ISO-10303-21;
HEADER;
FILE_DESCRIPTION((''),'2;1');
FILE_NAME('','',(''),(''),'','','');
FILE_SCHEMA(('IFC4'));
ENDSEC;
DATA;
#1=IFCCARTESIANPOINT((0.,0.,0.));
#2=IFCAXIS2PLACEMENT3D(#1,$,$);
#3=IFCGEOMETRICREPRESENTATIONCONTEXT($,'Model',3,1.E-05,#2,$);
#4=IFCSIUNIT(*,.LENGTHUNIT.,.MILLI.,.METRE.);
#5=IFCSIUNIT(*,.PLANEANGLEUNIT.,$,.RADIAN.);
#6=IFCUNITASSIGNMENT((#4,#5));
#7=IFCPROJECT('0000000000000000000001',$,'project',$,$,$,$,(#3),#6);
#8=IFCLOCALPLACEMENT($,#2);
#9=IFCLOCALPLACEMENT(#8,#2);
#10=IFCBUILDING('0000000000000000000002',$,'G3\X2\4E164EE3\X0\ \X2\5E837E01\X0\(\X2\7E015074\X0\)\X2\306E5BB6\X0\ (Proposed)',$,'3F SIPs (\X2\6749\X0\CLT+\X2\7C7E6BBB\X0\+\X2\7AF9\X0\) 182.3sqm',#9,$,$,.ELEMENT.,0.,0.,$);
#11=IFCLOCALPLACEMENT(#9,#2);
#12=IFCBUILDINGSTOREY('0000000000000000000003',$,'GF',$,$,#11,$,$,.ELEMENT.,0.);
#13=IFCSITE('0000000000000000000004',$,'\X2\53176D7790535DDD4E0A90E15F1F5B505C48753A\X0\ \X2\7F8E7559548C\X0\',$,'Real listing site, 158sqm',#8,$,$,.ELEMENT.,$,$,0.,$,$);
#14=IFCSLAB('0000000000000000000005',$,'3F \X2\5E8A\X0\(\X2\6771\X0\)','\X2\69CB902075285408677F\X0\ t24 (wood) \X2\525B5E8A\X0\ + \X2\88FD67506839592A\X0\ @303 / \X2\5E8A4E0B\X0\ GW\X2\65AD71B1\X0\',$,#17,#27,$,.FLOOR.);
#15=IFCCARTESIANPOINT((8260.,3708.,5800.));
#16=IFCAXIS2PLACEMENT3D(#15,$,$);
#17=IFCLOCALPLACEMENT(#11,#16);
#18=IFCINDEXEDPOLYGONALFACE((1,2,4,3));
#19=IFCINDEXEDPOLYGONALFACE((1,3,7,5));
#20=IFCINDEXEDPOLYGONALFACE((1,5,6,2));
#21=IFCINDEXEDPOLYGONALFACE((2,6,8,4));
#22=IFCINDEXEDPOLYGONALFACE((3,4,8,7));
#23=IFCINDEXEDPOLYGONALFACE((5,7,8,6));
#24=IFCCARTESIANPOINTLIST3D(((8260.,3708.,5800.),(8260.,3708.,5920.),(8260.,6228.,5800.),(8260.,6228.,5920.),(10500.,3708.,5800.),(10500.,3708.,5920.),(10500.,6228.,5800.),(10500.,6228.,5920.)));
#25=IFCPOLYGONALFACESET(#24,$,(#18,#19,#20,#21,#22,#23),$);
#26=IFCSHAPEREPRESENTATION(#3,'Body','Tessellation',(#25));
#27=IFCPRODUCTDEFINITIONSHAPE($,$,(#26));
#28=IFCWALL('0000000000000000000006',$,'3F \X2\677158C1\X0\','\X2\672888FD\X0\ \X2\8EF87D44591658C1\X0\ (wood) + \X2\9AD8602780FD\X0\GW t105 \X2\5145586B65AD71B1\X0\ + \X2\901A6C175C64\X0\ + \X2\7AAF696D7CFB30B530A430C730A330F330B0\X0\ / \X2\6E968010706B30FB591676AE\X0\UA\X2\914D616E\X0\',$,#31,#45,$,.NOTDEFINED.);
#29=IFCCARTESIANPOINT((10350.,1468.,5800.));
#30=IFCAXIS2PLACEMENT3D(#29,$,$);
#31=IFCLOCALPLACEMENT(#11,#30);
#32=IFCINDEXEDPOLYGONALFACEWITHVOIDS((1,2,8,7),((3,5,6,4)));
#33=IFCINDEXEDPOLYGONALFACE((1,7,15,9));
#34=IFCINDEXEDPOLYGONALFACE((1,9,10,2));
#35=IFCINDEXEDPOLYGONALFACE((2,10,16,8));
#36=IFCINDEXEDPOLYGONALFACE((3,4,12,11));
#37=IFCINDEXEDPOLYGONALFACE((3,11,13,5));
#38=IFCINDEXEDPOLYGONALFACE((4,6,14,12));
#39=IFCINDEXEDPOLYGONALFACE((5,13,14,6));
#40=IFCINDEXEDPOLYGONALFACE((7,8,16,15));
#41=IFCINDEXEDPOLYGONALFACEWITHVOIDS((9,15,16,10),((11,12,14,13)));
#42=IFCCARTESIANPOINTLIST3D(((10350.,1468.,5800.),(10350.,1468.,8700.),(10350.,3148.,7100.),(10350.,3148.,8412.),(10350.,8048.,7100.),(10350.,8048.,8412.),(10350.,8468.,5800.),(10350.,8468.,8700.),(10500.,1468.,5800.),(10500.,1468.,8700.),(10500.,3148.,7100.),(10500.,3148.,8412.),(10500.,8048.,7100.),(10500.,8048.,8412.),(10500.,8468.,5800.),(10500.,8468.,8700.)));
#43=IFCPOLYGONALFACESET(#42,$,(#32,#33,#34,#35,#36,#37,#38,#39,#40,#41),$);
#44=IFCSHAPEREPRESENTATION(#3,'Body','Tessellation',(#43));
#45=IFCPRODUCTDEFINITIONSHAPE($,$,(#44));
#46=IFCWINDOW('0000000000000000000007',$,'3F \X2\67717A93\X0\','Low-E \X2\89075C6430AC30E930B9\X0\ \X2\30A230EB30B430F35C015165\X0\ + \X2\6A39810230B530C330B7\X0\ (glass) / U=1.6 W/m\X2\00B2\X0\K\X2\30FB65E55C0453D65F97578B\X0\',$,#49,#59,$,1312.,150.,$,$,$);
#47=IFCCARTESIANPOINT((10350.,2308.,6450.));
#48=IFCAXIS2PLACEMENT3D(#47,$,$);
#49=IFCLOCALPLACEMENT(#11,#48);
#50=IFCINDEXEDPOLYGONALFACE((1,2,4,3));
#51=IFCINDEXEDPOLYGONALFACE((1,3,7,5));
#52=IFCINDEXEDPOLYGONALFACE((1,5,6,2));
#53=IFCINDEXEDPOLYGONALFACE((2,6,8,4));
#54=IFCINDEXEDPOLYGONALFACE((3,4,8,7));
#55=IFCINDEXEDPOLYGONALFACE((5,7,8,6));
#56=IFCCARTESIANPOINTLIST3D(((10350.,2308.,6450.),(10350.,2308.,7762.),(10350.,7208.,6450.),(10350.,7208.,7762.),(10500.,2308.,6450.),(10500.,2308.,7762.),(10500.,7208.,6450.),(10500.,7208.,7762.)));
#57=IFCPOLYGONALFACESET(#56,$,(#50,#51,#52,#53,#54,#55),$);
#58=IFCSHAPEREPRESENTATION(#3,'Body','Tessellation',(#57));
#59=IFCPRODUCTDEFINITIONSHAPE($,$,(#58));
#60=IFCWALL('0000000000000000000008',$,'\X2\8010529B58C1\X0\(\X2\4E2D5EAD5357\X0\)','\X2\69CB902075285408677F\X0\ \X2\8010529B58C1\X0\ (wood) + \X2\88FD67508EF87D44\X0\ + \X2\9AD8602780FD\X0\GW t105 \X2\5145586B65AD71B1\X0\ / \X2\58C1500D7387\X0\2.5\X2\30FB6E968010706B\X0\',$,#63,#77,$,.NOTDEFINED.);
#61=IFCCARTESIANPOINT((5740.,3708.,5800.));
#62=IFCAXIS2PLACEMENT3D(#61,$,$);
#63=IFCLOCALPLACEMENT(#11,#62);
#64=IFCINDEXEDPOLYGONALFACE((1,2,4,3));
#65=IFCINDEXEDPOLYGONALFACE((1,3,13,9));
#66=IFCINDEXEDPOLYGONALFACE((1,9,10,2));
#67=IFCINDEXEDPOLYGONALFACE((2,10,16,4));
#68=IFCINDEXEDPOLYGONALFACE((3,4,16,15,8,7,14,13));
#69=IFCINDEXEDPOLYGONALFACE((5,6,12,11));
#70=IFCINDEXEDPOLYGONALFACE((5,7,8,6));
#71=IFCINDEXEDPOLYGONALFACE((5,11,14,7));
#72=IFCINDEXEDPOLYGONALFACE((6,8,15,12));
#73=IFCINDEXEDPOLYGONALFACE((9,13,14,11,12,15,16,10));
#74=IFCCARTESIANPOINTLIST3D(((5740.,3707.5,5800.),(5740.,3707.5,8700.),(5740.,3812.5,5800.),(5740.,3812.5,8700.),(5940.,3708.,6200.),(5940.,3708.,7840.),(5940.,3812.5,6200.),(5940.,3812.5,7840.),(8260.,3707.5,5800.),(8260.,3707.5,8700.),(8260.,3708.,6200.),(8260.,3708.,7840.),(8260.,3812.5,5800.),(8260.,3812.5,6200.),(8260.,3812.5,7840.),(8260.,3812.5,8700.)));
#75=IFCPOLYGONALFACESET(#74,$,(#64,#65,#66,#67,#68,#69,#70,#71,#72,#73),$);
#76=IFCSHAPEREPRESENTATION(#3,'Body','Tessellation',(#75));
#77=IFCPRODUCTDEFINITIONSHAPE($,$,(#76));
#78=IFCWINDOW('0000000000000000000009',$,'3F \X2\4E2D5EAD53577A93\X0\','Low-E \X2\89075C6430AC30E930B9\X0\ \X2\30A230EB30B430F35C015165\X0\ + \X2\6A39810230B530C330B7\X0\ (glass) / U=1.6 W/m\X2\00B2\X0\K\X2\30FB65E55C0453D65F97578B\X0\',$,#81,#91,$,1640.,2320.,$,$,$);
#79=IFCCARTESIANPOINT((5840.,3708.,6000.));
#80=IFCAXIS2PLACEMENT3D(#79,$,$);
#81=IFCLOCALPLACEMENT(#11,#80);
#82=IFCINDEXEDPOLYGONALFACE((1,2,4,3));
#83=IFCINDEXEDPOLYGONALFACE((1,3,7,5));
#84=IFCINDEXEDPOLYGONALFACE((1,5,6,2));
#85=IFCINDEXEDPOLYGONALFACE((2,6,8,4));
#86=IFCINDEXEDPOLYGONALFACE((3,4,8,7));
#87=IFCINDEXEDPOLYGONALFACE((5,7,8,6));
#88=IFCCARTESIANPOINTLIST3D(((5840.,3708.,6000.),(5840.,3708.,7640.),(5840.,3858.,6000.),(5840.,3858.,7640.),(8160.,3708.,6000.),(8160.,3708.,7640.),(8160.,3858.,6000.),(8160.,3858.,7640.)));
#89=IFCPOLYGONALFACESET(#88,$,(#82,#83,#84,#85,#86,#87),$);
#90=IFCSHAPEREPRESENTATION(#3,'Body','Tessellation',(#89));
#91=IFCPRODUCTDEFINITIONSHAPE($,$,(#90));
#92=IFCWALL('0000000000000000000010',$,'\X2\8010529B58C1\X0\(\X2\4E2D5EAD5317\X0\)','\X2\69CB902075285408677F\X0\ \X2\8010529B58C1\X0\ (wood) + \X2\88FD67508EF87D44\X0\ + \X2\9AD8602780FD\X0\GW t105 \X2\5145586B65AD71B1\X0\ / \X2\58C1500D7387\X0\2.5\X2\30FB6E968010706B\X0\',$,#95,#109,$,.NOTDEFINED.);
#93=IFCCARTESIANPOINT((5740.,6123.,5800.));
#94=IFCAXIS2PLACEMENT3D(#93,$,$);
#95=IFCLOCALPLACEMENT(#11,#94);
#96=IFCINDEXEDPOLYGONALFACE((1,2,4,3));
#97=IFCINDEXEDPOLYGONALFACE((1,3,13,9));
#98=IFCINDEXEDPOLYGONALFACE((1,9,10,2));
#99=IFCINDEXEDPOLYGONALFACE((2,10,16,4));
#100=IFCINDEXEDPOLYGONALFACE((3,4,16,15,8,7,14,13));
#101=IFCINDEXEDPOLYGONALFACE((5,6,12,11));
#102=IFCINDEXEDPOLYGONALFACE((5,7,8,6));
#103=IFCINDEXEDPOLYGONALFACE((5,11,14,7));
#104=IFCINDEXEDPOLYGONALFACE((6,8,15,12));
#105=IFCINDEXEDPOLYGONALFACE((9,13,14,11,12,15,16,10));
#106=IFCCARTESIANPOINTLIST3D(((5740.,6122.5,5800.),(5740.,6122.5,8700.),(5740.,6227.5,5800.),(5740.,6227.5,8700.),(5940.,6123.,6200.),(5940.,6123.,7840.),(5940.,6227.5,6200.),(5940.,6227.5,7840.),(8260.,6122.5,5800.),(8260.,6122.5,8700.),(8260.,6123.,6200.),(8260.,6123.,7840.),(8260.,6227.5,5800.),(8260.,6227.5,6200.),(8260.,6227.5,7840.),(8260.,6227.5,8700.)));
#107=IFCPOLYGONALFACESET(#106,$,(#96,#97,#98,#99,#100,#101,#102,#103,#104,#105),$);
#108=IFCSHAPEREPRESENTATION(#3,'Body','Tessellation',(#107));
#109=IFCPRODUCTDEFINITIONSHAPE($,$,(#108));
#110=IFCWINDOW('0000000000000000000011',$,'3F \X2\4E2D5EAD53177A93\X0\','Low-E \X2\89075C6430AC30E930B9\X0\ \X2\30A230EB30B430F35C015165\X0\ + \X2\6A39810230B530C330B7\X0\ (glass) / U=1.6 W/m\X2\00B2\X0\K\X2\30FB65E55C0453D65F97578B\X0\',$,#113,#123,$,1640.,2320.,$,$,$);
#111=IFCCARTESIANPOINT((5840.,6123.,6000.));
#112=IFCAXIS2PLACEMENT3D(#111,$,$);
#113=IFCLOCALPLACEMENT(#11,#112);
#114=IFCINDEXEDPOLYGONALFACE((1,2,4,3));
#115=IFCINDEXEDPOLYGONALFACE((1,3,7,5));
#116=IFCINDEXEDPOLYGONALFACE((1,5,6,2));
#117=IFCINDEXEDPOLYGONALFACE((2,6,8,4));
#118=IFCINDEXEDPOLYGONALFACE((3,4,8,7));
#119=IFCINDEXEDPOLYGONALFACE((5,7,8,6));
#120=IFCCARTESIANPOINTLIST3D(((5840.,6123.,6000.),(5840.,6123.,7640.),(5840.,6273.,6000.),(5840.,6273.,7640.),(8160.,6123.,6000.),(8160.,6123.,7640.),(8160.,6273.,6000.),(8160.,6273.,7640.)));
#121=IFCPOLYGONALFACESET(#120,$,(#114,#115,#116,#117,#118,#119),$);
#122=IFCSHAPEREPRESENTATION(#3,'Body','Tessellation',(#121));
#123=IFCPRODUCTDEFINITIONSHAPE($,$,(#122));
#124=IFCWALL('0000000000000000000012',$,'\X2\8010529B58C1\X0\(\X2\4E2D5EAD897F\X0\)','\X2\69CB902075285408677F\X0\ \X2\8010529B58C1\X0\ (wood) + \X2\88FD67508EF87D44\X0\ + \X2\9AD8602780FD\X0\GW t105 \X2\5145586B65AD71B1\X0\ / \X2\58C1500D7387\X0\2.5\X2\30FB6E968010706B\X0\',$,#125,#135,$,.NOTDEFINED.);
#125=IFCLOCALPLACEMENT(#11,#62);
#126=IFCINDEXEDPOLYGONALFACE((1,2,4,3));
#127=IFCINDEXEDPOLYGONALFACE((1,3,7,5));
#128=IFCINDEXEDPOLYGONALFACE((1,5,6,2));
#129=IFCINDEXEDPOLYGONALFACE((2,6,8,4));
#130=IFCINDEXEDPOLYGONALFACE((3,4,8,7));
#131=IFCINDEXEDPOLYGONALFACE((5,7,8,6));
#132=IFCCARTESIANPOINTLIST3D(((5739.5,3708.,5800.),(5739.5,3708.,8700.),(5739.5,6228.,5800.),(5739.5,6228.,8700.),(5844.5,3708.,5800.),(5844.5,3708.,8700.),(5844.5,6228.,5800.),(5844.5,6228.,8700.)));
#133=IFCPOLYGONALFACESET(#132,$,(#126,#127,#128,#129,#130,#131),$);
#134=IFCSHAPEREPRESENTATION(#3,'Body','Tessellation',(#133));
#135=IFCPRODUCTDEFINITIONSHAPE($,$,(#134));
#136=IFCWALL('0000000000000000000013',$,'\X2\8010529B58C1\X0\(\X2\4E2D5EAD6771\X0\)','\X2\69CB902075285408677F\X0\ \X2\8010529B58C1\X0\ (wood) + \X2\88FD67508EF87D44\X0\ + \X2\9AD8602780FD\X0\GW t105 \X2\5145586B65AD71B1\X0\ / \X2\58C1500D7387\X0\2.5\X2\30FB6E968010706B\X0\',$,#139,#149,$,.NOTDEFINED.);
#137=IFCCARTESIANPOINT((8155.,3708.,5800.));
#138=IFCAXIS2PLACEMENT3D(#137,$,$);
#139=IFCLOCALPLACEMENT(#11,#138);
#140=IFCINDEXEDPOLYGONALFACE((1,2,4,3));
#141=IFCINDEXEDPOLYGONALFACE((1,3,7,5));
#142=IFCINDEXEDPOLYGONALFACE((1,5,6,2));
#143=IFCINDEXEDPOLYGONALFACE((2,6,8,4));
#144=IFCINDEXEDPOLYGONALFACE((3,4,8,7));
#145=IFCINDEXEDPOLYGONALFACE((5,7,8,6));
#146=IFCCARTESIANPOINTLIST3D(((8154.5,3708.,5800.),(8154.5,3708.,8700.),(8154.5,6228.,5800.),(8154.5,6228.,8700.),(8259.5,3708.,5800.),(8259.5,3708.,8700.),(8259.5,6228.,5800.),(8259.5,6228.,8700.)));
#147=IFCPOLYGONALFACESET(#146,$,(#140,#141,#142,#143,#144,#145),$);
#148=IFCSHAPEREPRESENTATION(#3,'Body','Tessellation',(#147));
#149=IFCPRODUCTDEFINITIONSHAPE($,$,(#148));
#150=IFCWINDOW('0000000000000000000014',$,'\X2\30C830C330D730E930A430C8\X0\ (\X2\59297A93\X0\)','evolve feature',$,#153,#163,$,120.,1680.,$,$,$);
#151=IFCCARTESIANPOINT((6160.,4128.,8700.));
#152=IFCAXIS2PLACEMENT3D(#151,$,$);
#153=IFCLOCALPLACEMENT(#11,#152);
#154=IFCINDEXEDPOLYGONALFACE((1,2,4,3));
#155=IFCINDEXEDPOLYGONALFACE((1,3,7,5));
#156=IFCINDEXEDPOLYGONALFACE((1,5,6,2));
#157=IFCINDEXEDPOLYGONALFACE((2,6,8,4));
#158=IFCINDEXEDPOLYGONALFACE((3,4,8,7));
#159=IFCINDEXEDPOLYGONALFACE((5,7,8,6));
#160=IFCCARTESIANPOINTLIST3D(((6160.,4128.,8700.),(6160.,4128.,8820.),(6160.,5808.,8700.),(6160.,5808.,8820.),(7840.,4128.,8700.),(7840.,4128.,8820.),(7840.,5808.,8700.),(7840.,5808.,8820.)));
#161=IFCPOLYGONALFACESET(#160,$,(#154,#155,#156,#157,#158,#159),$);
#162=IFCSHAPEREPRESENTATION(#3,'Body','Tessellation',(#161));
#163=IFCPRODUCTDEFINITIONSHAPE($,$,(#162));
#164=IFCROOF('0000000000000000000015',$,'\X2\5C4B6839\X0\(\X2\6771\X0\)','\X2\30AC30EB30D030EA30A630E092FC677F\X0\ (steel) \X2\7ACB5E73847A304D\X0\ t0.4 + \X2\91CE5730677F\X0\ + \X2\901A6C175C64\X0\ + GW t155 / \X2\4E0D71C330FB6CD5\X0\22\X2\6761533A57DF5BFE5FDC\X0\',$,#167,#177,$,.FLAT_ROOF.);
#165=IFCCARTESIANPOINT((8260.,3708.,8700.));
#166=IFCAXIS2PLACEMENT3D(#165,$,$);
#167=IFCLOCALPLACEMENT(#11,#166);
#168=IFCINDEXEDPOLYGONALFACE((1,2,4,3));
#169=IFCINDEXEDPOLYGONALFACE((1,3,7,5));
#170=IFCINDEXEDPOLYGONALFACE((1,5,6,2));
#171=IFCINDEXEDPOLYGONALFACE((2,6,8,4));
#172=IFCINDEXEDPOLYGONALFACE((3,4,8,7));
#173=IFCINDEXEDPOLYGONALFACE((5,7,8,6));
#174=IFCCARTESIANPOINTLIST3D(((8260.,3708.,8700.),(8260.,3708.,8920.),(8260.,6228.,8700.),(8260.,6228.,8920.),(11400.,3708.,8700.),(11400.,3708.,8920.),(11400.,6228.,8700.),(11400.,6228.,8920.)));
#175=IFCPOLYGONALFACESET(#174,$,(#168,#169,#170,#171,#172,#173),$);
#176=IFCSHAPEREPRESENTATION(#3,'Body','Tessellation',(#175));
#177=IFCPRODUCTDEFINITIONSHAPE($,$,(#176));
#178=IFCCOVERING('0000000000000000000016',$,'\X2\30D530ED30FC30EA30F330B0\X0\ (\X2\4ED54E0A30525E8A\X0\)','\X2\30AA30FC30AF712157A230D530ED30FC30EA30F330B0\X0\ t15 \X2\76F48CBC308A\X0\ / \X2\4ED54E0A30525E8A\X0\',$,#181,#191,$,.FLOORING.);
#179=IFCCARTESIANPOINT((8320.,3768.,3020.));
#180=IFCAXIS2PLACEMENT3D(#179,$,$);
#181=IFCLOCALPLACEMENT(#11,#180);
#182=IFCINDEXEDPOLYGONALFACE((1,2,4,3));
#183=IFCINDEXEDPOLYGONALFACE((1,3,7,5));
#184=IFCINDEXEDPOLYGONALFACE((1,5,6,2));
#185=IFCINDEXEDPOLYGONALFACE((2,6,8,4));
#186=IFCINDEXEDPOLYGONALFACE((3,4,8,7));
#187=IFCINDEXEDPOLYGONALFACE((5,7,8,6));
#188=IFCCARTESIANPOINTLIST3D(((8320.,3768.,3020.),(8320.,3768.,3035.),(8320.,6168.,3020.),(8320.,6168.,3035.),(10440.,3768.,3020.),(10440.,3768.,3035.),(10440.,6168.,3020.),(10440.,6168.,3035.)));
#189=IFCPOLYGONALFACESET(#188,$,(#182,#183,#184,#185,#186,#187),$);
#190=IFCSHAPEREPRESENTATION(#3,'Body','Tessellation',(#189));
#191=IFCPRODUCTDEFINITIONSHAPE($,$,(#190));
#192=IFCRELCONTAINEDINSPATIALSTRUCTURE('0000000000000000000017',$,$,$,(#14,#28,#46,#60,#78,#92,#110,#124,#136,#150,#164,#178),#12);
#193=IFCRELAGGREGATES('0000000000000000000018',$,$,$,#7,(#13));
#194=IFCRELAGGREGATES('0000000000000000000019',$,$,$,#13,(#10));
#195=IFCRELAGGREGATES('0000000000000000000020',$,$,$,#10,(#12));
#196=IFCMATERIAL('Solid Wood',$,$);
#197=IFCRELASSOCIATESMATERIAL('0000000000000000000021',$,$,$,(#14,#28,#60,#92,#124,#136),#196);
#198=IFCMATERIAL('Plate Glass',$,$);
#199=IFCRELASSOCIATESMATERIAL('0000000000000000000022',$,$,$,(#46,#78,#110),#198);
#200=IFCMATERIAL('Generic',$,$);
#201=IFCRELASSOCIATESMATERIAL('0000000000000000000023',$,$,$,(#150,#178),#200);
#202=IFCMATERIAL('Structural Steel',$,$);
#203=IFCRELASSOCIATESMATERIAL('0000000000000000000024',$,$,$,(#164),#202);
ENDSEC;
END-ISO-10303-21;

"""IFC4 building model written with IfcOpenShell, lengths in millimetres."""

from ifc_helpers import new_model, si_unit, frame, frame_2d, origin, place, context, project, spatial, rectangle, extrude, material, element, fill, save


model = new_model("IFC4")

# Units and contexts
model_context = context("Model", 3, precision=1e-05, world=origin())
ifc_project = project(units=[si_unit("LENGTHUNIT", "METRE", prefix="MILLI"), si_unit("PLANEANGLEUNIT", "RADIAN")], contexts=[model_context])

# Site, building, storey
site_placement = place(None, origin())
site = spatial("IfcSite", under=ifc_project, at=site_placement, Name="北海道川上郡弟子屈町 美留和", ObjectType="Real listing site, 158sqm", CompositionType="ELEMENT", RefElevation=0.0)
building_placement = place(site_placement, origin())
building = spatial("IfcBuilding", under=site, at=building_placement, Name="G3世代 広縁(縁側)の家 (Proposed)", ObjectType="3F SIPs (杉CLT+籾殻+竹) 182.3sqm", CompositionType="ELEMENT", ElevationOfRefHeight=0.0, ElevationOfTerrain=0.0)
storey_placement = place(building_placement, origin())
storey = spatial("IfcBuildingStorey", under=building, at=storey_placement, Name="GF", CompositionType="ELEMENT", Elevation=0.0)

# Slab
ifc_material_1 = material(Name="Solid Wood")
slab_placement = place(storey_placement, frame((8260.0, 3708.0, 5800.0)))
element("IfcSlab", 1, at=slab_placement, inside=storey, material=ifc_material_1, Name="3F 床(東)", Description="構造用合板 t24 (wood) 剛床 + 製材根太 @303 / 床下 GW断熱", PredefinedType="FLOOR", context=model_context, shape_type="SweptSolid", body=[
    extrude(rectangle(XDim=2240.0, YDim=2520.0, at=frame_2d((1120.0, 1260.0))), frame((8260.0, 3708.0, 5800.0)), (0.0, 0.0, 1.0), 120.0),
])

# Walls, openings, windows
wall_1_placement = place(storey_placement, frame((10350.0, 1468.0, 5800.0)))
wall_1 = element("IfcWall", 2, at=wall_1_placement, inside=storey, material=ifc_material_1, Name="3F 東壁", Description="木製 軸組外壁 (wood) + 高性能GW t105 充填断熱 + 通気層 + 窯業系サイディング / 準耐火・外皮UA配慮", PredefinedType="NOTDEFINED", context=model_context, shape_type="SweptSolid", body=[
    extrude(rectangle(XDim=150.0, YDim=7000.0, at=frame_2d((75.0, 3500.0))), frame((10350.0, 1468.0, 5800.0)), (0.0, 0.0, 1.0), 2900.0),
])
opening_1_placement = place(storey_placement, frame((10350.0, 2308.0, 6450.0)))
opening_1 = element("IfcOpeningElement", 3, at=opening_1_placement, cuts=wall_1, PredefinedType="NOTDEFINED", context=model_context, shape_type="SweptSolid", body=[
    extrude(rectangle(XDim=150.0, YDim=4900.0, at=frame_2d((75.0, 2450.0))), frame((10350.0, 2308.0, 6450.0)), (0.0, 0.0, 1.0), 1312.0),
])
ifc_material_2 = material(Name="Plate Glass")
window_1_placement = place(storey_placement, frame((10350.0, 2308.0, 6450.0)))
window_1 = element("IfcWindow", 4, at=window_1_placement, inside=storey, material=ifc_material_2, Name="3F 東窓", Description="Low-E 複層ガラス アルゴン封入 + 樹脂サッシ (glass) / U=1.6 W/m²K・日射取得型", OverallHeight=1312.0, OverallWidth=150.0, context=model_context, shape_type="SweptSolid", body=[
    extrude(rectangle(XDim=150.0, YDim=4900.0, at=frame_2d((75.0, 2450.0))), frame((10350.0, 2308.0, 6450.0)), (0.0, 0.0, 1.0), 1312.0),
])
fill(opening_1, window_1)
wall_2_placement = place(storey_placement, frame((5740.0, 3708.0, 5800.0)))
wall_2 = element("IfcWall", 5, at=wall_2_placement, inside=storey, material=ifc_material_1, Name="耐力壁(中庭南)", Description="構造用合板 耐力壁 (wood) + 製材軸組 + 高性能GW t105 充填断熱 / 壁倍率2.5・準耐火", PredefinedType="NOTDEFINED", context=model_context, shape_type="SweptSolid", body=[
    extrude(rectangle(XDim=2520.0, YDim=105.0, at=frame_2d((1260.0, 52.0))), frame((5740.0, 3708.0, 5800.0)), (0.0, 0.0, 1.0), 2900.0),
])
opening_2_placement = place(storey_placement, frame((5840.0, 3708.0, 6000.0)))
opening_2 = element("IfcOpeningElement", 6, at=opening_2_placement, cuts=wall_2, PredefinedType="NOTDEFINED", context=model_context, shape_type="SweptSolid", body=[
    extrude(rectangle(XDim=2320.0, YDim=150.0, at=frame_2d((1160.0, 75.0))), frame((5840.0, 3708.0, 6000.0)), (0.0, 0.0, 1.0), 1640.0),
])
window_2_placement = place(storey_placement, frame((5840.0, 3708.0, 6000.0)))
window_2 = element("IfcWindow", 7, at=window_2_placement, inside=storey, material=ifc_material_2, Name="3F 中庭南窓", Description="Low-E 複層ガラス アルゴン封入 + 樹脂サッシ (glass) / U=1.6 W/m²K・日射取得型", OverallHeight=1640.0, OverallWidth=2320.0, context=model_context, shape_type="SweptSolid", body=[
    extrude(rectangle(XDim=2320.0, YDim=150.0, at=frame_2d((1160.0, 75.0))), frame((5840.0, 3708.0, 6000.0)), (0.0, 0.0, 1.0), 1640.0),
])
fill(opening_2, window_2)
wall_3_placement = place(storey_placement, frame((5740.0, 6123.0, 5800.0)))
wall_3 = element("IfcWall", 8, at=wall_3_placement, inside=storey, material=ifc_material_1, Name="耐力壁(中庭北)", Description="構造用合板 耐力壁 (wood) + 製材軸組 + 高性能GW t105 充填断熱 / 壁倍率2.5・準耐火", PredefinedType="NOTDEFINED", context=model_context, shape_type="SweptSolid", body=[
    extrude(rectangle(XDim=2520.0, YDim=105.0, at=frame_2d((1260.0, 52.0))), frame((5740.0, 6123.0, 5800.0)), (0.0, 0.0, 1.0), 2900.0),
])
opening_3_placement = place(storey_placement, frame((5840.0, 6123.0, 6000.0)))
opening_3 = element("IfcOpeningElement", 9, at=opening_3_placement, cuts=wall_3, PredefinedType="NOTDEFINED", context=model_context, shape_type="SweptSolid", body=[
    extrude(rectangle(XDim=2320.0, YDim=150.0, at=frame_2d((1160.0, 75.0))), frame((5840.0, 6123.0, 6000.0)), (0.0, 0.0, 1.0), 1640.0),
])
window_3_placement = place(storey_placement, frame((5840.0, 6123.0, 6000.0)))
window_3 = element("IfcWindow", 10, at=window_3_placement, inside=storey, material=ifc_material_2, Name="3F 中庭北窓", Description="Low-E 複層ガラス アルゴン封入 + 樹脂サッシ (glass) / U=1.6 W/m²K・日射取得型", OverallHeight=1640.0, OverallWidth=2320.0, context=model_context, shape_type="SweptSolid", body=[
    extrude(rectangle(XDim=2320.0, YDim=150.0, at=frame_2d((1160.0, 75.0))), frame((5840.0, 6123.0, 6000.0)), (0.0, 0.0, 1.0), 1640.0),
])
fill(opening_3, window_3)

# Walls
wall_4_placement = place(storey_placement, frame((5740.0, 3708.0, 5800.0)))
element("IfcWall", 11, at=wall_4_placement, inside=storey, material=ifc_material_1, Name="耐力壁(中庭西)", Description="構造用合板 耐力壁 (wood) + 製材軸組 + 高性能GW t105 充填断熱 / 壁倍率2.5・準耐火", PredefinedType="NOTDEFINED", context=model_context, shape_type="SweptSolid", body=[
    extrude(rectangle(XDim=105.0, YDim=2520.0, at=frame_2d((52.0, 1260.0))), frame((5740.0, 3708.0, 5800.0)), (0.0, 0.0, 1.0), 2900.0),
])
wall_5_placement = place(storey_placement, frame((8155.0, 3708.0, 5800.0)))
element("IfcWall", 12, at=wall_5_placement, inside=storey, material=ifc_material_1, Name="耐力壁(中庭東)", Description="構造用合板 耐力壁 (wood) + 製材軸組 + 高性能GW t105 充填断熱 / 壁倍率2.5・準耐火", PredefinedType="NOTDEFINED", context=model_context, shape_type="SweptSolid", body=[
    extrude(rectangle(XDim=105.0, YDim=2520.0, at=frame_2d((52.0, 1260.0))), frame((8155.0, 3708.0, 5800.0)), (0.0, 0.0, 1.0), 2900.0),
])

# Window
ifc_material_3 = material(Name="Generic")
window_4_placement = place(storey_placement, frame((6160.0, 4128.0, 8700.0)))
element("IfcWindow", 13, at=window_4_placement, inside=storey, material=ifc_material_3, Name="トップライト (天窓)", Description="evolve feature", OverallHeight=120.0, OverallWidth=1680.0, context=model_context, shape_type="SweptSolid", body=[
    extrude(rectangle(XDim=1680.0, YDim=1680.0, at=frame_2d((840.0, 840.0))), frame((6160.0, 4128.0, 8700.0)), (0.0, 0.0, 1.0), 120.0),
])

# Roof
ifc_material_4 = material(Name="Structural Steel")
for number, where, name in (
    (14, (8260.0, 3708.0, 8700.0), "屋根(東)"),
):
    element("IfcRoof", number, at=place(storey_placement, frame(where)), inside=storey, material=ifc_material_4, Name=name, Description="ガルバリウム鋼板 (steel) 立平葺き t0.4 + 野地板 + 通気層 + GW t155 / 不燃・法22条区域対応", PredefinedType="FLAT_ROOF", context=model_context, shape_type="SweptSolid", body=[
        extrude(rectangle(XDim=3140.0, YDim=2520.0, at=frame_2d((1570.0, 1260.0))), frame((8260.0, 3708.0, 8700.0)), (0.0, 0.0, 1.0), 220.0),
    ])

# Covering
covering_1_placement = place(storey_placement, frame((8320.0, 3768.0, 3020.0)))
element("IfcCovering", 15, at=covering_1_placement, inside=storey, material=ifc_material_3, Name="フローリング (仕上げ床)", Description="オーク無垢フローリング t15 直貼り / 仕上げ床", PredefinedType="FLOORING", context=model_context, shape_type="SweptSolid", body=[
    extrude(rectangle(XDim=2120.0, YDim=2400.0, at=frame_2d((1060.0, 1200.0))), frame((8320.0, 3768.0, 3020.0)), (0.0, 0.0, 1.0), 15.0),
])

save(model, "model.ifc")
